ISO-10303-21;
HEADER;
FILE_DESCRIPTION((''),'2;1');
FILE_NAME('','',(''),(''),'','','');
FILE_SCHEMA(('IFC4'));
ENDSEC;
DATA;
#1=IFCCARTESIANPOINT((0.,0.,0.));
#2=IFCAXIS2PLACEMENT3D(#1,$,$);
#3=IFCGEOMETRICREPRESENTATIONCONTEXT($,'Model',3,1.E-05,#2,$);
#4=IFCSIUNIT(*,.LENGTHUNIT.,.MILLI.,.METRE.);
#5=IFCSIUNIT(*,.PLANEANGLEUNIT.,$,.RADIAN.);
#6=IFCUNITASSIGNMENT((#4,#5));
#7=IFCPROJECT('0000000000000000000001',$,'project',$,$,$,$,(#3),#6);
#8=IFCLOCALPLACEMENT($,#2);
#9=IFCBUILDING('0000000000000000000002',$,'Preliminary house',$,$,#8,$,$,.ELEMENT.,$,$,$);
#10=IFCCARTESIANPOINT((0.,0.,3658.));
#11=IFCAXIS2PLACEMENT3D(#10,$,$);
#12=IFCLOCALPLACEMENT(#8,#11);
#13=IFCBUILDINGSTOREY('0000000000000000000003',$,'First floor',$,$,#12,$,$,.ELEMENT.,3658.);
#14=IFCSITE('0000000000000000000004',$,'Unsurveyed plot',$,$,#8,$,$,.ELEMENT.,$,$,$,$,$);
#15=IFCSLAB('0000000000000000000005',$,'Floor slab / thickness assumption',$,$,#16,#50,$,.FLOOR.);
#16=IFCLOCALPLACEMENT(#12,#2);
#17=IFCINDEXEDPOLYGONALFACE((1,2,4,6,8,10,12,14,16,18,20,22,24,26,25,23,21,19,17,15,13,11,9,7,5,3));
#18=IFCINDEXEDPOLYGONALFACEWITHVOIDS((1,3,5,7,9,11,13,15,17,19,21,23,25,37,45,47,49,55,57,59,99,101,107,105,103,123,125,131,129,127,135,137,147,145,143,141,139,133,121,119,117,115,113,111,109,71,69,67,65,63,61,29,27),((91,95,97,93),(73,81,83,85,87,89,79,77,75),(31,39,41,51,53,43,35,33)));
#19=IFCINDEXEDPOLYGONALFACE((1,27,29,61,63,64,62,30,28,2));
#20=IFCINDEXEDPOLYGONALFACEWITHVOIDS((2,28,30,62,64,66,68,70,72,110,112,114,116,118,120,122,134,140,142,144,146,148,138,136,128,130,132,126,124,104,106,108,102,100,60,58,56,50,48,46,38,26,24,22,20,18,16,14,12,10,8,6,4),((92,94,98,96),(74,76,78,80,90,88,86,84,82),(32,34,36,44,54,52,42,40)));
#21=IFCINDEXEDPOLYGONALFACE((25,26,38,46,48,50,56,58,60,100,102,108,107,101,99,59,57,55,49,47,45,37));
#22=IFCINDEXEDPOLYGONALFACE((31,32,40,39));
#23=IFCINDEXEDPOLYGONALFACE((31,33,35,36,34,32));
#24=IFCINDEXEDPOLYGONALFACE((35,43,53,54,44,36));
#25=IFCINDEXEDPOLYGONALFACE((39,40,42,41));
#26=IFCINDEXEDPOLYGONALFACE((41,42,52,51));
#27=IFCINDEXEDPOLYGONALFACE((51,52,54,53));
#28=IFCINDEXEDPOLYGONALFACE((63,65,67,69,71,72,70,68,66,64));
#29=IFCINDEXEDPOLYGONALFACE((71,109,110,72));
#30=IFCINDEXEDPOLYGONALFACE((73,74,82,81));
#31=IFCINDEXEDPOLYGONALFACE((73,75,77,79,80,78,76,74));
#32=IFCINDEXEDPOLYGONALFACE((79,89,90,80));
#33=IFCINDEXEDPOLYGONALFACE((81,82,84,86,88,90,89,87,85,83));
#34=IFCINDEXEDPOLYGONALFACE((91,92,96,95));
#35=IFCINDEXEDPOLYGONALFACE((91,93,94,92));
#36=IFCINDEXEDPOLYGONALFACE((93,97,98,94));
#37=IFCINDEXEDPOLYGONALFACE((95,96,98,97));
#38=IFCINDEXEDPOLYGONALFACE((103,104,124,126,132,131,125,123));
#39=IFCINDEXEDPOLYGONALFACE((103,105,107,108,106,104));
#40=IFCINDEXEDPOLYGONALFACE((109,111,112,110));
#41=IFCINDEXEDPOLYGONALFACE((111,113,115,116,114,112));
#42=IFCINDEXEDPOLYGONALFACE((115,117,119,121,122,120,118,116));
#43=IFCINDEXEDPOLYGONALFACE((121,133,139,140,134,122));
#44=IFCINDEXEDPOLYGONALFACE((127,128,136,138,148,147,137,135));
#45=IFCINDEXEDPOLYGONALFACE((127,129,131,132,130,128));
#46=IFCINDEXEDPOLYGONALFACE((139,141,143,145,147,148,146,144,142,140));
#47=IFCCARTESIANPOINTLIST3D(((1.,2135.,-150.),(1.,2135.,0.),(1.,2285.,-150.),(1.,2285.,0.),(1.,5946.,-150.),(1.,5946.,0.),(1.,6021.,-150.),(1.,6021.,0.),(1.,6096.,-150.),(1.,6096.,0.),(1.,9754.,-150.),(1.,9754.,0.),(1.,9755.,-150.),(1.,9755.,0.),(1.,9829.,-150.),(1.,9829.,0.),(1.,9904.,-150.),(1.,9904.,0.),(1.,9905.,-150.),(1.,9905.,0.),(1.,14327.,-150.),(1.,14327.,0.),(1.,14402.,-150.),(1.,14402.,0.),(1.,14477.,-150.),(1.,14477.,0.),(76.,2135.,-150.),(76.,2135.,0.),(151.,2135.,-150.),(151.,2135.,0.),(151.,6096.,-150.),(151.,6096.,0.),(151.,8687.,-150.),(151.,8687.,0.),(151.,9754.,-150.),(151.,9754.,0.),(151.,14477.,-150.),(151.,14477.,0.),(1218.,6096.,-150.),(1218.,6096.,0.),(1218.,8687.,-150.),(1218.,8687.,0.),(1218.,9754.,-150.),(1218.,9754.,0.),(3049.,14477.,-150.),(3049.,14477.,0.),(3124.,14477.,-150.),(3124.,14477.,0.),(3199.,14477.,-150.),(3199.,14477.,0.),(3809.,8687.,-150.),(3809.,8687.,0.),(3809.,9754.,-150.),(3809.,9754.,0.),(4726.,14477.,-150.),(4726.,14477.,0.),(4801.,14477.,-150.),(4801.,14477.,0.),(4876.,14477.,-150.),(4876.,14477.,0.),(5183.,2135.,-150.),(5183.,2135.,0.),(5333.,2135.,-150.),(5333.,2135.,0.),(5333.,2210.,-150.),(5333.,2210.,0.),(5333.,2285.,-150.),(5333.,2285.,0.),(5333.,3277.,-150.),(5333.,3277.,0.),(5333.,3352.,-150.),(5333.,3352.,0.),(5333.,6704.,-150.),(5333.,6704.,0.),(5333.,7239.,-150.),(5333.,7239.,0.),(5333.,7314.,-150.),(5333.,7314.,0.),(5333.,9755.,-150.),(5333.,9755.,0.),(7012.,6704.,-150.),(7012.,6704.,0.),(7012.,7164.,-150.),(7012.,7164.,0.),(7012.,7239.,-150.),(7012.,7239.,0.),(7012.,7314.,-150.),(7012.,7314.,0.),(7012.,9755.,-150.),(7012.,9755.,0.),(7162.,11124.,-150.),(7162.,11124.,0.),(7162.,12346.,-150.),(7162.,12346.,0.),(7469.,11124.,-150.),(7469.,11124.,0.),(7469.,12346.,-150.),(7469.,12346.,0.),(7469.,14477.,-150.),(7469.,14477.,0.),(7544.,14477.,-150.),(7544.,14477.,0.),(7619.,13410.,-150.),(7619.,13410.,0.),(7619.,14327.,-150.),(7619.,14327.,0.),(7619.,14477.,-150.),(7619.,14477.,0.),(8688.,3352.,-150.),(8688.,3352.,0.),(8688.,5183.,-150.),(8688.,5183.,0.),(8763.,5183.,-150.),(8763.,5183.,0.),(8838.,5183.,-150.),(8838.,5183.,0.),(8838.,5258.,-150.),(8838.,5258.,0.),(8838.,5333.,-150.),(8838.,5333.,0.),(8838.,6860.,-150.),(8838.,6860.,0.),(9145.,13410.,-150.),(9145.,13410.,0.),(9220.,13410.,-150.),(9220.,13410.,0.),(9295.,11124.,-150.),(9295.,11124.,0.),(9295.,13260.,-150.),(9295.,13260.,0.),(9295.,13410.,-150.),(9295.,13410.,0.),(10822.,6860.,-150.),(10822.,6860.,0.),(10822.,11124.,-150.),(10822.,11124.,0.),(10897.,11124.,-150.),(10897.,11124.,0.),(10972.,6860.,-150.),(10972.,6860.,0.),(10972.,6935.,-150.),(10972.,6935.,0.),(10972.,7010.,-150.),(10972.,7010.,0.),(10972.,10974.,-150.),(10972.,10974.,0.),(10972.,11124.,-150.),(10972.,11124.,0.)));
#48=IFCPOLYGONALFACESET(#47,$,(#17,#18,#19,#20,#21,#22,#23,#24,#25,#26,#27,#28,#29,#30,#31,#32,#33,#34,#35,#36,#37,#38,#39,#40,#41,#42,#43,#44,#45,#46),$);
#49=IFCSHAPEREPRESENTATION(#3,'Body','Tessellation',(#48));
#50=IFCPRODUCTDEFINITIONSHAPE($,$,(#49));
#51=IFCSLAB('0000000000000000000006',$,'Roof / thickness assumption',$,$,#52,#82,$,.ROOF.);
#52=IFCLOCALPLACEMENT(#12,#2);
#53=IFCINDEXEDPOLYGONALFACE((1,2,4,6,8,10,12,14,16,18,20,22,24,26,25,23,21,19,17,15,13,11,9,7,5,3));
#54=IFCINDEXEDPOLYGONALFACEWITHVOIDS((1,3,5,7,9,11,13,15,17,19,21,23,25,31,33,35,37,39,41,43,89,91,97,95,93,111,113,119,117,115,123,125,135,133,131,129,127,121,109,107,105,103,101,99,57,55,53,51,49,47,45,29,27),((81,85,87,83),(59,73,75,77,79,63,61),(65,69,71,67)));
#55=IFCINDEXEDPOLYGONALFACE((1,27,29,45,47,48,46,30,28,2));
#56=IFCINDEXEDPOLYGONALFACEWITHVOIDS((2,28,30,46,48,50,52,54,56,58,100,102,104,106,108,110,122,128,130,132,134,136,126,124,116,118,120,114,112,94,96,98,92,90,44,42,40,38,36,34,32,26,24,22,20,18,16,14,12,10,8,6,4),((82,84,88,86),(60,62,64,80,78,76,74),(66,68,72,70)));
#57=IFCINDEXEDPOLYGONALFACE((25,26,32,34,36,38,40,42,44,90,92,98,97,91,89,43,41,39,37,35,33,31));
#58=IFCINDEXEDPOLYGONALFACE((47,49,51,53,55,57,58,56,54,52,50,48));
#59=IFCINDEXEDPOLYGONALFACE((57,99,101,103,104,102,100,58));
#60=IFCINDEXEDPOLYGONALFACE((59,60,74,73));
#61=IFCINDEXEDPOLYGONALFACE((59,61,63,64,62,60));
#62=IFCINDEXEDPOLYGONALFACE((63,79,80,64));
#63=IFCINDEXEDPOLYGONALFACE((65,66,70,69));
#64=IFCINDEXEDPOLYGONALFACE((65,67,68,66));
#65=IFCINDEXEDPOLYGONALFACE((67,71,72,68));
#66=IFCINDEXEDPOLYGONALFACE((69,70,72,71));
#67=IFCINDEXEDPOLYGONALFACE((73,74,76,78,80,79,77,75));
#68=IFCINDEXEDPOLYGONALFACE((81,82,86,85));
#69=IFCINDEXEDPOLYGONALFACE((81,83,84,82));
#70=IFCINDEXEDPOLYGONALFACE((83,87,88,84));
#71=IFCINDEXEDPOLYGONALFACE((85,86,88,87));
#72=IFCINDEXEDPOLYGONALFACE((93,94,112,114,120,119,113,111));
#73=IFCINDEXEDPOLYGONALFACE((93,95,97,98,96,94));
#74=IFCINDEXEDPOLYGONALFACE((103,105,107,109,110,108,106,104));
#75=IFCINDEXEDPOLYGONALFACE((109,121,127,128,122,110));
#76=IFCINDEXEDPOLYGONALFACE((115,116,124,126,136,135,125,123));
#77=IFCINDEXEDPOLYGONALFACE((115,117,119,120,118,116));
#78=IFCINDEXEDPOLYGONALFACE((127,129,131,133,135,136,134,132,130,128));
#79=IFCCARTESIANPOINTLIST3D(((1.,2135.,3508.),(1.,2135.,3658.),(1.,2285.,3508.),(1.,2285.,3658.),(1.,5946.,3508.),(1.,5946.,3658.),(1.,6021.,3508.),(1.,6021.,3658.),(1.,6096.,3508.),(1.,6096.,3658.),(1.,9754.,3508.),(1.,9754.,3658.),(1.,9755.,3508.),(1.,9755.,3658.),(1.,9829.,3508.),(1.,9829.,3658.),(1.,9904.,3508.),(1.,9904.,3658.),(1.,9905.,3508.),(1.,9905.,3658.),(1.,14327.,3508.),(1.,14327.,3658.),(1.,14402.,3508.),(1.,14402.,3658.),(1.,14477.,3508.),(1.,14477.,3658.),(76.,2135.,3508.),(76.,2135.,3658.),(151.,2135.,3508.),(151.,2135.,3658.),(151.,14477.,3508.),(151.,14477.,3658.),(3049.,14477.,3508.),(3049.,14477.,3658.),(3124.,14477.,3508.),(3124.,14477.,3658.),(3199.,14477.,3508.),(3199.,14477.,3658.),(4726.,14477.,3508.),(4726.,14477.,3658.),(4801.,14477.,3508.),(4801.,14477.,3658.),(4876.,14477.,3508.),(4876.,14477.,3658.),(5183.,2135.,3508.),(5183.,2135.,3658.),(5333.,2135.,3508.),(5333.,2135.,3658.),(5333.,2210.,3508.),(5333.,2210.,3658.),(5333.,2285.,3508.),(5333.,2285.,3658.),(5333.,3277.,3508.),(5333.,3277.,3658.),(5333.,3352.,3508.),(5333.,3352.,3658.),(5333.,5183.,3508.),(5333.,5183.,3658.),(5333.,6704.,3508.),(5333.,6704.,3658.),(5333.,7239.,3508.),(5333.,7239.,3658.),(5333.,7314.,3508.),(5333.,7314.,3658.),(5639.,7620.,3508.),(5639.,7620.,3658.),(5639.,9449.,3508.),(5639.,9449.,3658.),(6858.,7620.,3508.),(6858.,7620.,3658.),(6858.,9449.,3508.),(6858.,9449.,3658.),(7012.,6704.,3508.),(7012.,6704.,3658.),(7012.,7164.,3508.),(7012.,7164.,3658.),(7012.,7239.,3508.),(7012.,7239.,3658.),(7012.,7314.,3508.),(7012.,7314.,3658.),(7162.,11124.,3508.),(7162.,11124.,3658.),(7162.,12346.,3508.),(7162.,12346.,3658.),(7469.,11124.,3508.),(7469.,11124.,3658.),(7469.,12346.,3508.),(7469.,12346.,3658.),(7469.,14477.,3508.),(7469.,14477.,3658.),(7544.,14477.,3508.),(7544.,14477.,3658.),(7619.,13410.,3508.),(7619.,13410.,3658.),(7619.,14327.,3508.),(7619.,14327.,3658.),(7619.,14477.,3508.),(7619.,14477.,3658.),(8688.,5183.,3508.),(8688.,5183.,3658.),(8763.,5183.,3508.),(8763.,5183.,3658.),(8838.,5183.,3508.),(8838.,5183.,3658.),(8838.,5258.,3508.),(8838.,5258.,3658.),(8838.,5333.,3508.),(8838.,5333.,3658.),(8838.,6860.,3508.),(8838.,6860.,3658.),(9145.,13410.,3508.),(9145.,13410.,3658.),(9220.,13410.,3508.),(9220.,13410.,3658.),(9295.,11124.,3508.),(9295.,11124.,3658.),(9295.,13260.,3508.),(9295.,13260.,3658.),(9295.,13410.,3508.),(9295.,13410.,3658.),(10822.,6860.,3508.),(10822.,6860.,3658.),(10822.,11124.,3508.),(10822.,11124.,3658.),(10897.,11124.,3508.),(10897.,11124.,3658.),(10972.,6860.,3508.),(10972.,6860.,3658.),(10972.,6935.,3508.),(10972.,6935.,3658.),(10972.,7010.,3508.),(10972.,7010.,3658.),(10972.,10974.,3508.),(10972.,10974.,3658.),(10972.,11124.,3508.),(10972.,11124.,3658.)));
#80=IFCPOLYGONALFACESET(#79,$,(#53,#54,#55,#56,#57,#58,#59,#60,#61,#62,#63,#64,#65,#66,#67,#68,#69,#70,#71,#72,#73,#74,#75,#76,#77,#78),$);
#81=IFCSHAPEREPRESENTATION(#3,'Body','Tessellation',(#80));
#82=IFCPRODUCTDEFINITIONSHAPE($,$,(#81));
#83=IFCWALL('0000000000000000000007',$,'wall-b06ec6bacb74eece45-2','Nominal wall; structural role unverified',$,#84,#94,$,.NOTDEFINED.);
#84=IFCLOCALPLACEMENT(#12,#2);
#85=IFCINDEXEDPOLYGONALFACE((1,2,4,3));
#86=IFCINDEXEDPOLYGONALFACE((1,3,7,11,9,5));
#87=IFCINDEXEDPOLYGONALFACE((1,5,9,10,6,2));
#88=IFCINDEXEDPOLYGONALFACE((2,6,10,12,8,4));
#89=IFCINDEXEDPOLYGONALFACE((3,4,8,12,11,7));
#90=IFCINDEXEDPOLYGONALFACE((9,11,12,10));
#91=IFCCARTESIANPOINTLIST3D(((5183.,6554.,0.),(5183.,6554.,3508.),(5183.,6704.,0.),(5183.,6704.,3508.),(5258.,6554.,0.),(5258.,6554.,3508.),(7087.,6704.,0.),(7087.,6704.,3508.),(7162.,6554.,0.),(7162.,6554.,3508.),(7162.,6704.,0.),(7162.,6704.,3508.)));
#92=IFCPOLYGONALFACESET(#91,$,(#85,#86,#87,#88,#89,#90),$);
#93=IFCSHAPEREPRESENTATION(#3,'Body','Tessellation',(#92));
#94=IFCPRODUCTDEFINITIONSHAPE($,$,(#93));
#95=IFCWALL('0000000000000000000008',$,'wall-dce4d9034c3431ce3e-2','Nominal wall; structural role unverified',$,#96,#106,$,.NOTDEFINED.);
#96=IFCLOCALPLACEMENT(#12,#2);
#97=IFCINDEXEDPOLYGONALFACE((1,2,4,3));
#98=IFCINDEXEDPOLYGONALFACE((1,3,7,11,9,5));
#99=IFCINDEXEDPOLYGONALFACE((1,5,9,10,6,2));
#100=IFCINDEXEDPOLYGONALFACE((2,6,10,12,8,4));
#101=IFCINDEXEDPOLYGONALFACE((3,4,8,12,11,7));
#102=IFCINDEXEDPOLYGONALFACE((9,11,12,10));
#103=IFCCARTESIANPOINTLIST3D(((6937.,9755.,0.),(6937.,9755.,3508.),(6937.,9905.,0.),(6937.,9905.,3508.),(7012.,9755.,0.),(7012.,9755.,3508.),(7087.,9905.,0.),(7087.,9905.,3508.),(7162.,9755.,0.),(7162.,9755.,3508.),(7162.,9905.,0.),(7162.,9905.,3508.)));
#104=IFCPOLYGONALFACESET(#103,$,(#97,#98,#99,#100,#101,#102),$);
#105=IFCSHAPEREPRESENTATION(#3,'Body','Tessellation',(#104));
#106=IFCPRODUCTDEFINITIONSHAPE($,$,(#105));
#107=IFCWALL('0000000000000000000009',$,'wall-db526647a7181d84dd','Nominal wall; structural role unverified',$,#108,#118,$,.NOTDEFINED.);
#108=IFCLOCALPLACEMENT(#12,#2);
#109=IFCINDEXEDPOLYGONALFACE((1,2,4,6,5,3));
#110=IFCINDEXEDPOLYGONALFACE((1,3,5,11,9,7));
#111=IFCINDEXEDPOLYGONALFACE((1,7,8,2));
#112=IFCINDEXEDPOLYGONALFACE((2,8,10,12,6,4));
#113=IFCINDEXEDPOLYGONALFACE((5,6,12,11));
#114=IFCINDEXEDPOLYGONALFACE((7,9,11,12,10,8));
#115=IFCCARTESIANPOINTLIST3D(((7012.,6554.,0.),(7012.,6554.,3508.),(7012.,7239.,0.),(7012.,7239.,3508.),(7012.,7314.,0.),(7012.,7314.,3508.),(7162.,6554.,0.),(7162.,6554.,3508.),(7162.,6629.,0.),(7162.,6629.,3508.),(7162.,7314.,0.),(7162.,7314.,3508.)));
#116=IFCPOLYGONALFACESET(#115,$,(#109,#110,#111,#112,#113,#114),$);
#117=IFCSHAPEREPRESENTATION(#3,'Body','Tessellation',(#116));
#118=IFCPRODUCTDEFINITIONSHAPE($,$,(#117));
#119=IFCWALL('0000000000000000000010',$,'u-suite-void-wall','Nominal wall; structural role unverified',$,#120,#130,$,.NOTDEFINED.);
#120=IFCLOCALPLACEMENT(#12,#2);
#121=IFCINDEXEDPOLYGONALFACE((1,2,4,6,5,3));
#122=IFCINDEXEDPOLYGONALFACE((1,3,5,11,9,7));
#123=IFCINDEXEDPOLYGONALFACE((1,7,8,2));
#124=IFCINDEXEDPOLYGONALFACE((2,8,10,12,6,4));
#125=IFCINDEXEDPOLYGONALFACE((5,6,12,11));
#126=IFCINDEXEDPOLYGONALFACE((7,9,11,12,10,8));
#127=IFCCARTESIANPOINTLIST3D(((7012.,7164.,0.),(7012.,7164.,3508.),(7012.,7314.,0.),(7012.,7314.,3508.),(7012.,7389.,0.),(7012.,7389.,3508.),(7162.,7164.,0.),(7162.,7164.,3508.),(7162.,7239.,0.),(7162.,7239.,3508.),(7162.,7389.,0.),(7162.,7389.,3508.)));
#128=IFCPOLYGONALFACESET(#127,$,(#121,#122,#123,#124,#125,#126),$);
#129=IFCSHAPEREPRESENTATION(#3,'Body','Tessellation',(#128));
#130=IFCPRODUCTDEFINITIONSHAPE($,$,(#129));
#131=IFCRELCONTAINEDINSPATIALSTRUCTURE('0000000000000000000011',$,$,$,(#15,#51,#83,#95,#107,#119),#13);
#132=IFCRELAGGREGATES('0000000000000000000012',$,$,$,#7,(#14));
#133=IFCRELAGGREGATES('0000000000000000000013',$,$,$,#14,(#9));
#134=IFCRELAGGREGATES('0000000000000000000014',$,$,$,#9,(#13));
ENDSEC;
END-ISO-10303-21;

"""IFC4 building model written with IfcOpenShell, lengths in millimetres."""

from ifc_helpers import new_model, si_unit, frame, origin, place, context, project, spatial, polyline, outline, extrude, element, save


model = new_model("IFC4")

# Units and contexts
model_context = context("Model", 3, precision=1e-05, world=origin())
ifc_project = project(units=[si_unit("LENGTHUNIT", "METRE", prefix="MILLI"), si_unit("PLANEANGLEUNIT", "RADIAN")], contexts=[model_context])

# Site, building, storey
placement_1 = place(None, origin())
site = spatial("IfcSite", under=ifc_project, at=placement_1, Name="Unsurveyed plot", CompositionType="ELEMENT")
building = spatial("IfcBuilding", under=site, at=placement_1, Name="Preliminary house", CompositionType="ELEMENT")
placement_2 = place(placement_1, frame((0.0, 0.0, 3658.0)))
storey = spatial("IfcBuildingStorey", under=building, at=placement_2, Name="First floor", CompositionType="ELEMENT", Elevation=3658.0)

# Slabs
element("IfcSlab", 1, at=placement_2, inside=storey, Name="Floor slab / thickness assumption", PredefinedType="FLOOR", context=model_context, shape_type="SweptSolid", body=[
    extrude(outline(polyline([(1.0, 5946.0), (1.0, 6021.0), (1.0, 6096.0), (1.0, 9754.0), (1.0, 9755.0), (1.0, 9829.0), (1.0, 9904.0), (1.0, 9905.0), (1.0, 14327.0), (1.0, 14402.0), (1.0, 14477.0), (151.0, 14477.0), (3049.0, 14477.0), (3124.0, 14477.0), (3199.0, 14477.0), (4726.0, 14477.0), (4801.0, 14477.0), (4876.0, 14477.0), (7469.0, 14477.0), (7544.0, 14477.0), (7619.0, 14477.0), (7619.0, 14327.0), (7619.0, 13410.0), (9145.0, 13410.0), (9220.0, 13410.0), (9295.0, 13410.0), (9295.0, 13260.0), (9295.0, 11124.0), (10822.0, 11124.0), (10897.0, 11124.0), (10972.0, 11124.0), (10972.0, 10974.0), (10972.0, 7010.0), (10972.0, 6935.0), (10972.0, 6860.0), (10822.0, 6860.0), (8838.0, 6860.0), (8838.0, 5333.0), (8838.0, 5258.0), (8838.0, 5183.0), (8763.0, 5183.0), (8688.0, 5183.0), (8688.0, 3352.0), (5333.0, 3352.0), (5333.0, 3277.0), (5333.0, 2285.0), (5333.0, 2210.0), (5333.0, 2135.0), (5183.0, 2135.0), (151.0, 2135.0), (76.0, 2135.0), (1.0, 2135.0), (1.0, 2285.0), (1.0, 5946.0)]), holes=[polyline([(7012.0, 7239.0), (7012.0, 7314.0), (7012.0, 9755.0), (5333.0, 9755.0), (5333.0, 7314.0), (5333.0, 7239.0), (5333.0, 6704.0), (7012.0, 6704.0), (7012.0, 7164.0), (7012.0, 7239.0)]), polyline([(7469.0, 11124.0), (7469.0, 12346.0), (7162.0, 12346.0), (7162.0, 11124.0), (7469.0, 11124.0)]), polyline([(1218.0, 8687.0), (3809.0, 8687.0), (3809.0, 9754.0), (1218.0, 9754.0), (151.0, 9754.0), (151.0, 8687.0), (151.0, 6096.0), (1218.0, 6096.0), (1218.0, 8687.0)])]), frame((0.0, 0.0, -150.0)), (0.0, 0.0, 1.0), 150.0),
])
element("IfcSlab", 2, at=placement_2, inside=storey, Name="Roof / thickness assumption", PredefinedType="ROOF", context=model_context, shape_type="SweptSolid", body=[
    extrude(outline(polyline([(1.0, 5946.0), (1.0, 6021.0), (1.0, 6096.0), (1.0, 9754.0), (1.0, 9755.0), (1.0, 9829.0), (1.0, 9904.0), (1.0, 9905.0), (1.0, 14327.0), (1.0, 14402.0), (1.0, 14477.0), (151.0, 14477.0), (3049.0, 14477.0), (3124.0, 14477.0), (3199.0, 14477.0), (4726.0, 14477.0), (4801.0, 14477.0), (4876.0, 14477.0), (7469.0, 14477.0), (7544.0, 14477.0), (7619.0, 14477.0), (7619.0, 14327.0), (7619.0, 13410.0), (9145.0, 13410.0), (9220.0, 13410.0), (9295.0, 13410.0), (9295.0, 13260.0), (9295.0, 11124.0), (10822.0, 11124.0), (10897.0, 11124.0), (10972.0, 11124.0), (10972.0, 10974.0), (10972.0, 7010.0), (10972.0, 6935.0), (10972.0, 6860.0), (10822.0, 6860.0), (8838.0, 6860.0), (8838.0, 5333.0), (8838.0, 5258.0), (8838.0, 5183.0), (8763.0, 5183.0), (8688.0, 5183.0), (5333.0, 5183.0), (5333.0, 3352.0), (5333.0, 3277.0), (5333.0, 2285.0), (5333.0, 2210.0), (5333.0, 2135.0), (5183.0, 2135.0), (151.0, 2135.0), (76.0, 2135.0), (1.0, 2135.0), (1.0, 2285.0), (1.0, 5946.0)]), holes=[polyline([(7012.0, 7239.0), (7012.0, 7314.0), (5333.0, 7314.0), (5333.0, 7239.0), (5333.0, 6704.0), (7012.0, 6704.0), (7012.0, 7164.0), (7012.0, 7239.0)]), polyline([(7469.0, 11124.0), (7469.0, 12346.0), (7162.0, 12346.0), (7162.0, 11124.0), (7469.0, 11124.0)]), polyline([(6858.0, 7620.0), (6858.0, 9449.0), (5639.0, 9449.0), (5639.0, 7620.0), (6858.0, 7620.0)])]), frame((0.0, 0.0, 3508.0)), (0.0, 0.0, 1.0), 150.0),
])

# Walls
element("IfcWall", 3, at=placement_2, inside=storey, Name="wall-b06ec6bacb74eece45-2", Description="Nominal wall; structural role unverified", PredefinedType="NOTDEFINED", context=model_context, shape_type="SweptSolid", body=[
    extrude(outline(polyline([(7087.0, 6704.0), (7162.0, 6704.0), (7162.0, 6554.0), (5258.0, 6554.0), (5183.0, 6554.0), (5183.0, 6704.0), (7087.0, 6704.0)])), origin(), (0.0, 0.0, 1.0), 3508.0),
])
element("IfcWall", 4, at=placement_2, inside=storey, Name="wall-dce4d9034c3431ce3e-2", Description="Nominal wall; structural role unverified", PredefinedType="NOTDEFINED", context=model_context, shape_type="SweptSolid", body=[
    extrude(outline(polyline([(7087.0, 9905.0), (7162.0, 9905.0), (7162.0, 9755.0), (7012.0, 9755.0), (6937.0, 9755.0), (6937.0, 9905.0), (7087.0, 9905.0)])), origin(), (0.0, 0.0, 1.0), 3508.0),
])
element("IfcWall", 5, at=placement_2, inside=storey, Name="wall-db526647a7181d84dd", Description="Nominal wall; structural role unverified", PredefinedType="NOTDEFINED", context=model_context, shape_type="SweptSolid", body=[
    extrude(outline(polyline([(7012.0, 7239.0), (7012.0, 7314.0), (7162.0, 7314.0), (7162.0, 6629.0), (7162.0, 6554.0), (7012.0, 6554.0), (7012.0, 7239.0)])), origin(), (0.0, 0.0, 1.0), 3508.0),
])
element("IfcWall", 6, at=placement_2, inside=storey, Name="u-suite-void-wall", Description="Nominal wall; structural role unverified", PredefinedType="NOTDEFINED", context=model_context, shape_type="SweptSolid", body=[
    extrude(outline(polyline([(7012.0, 7314.0), (7012.0, 7389.0), (7162.0, 7389.0), (7162.0, 7239.0), (7162.0, 7164.0), (7012.0, 7164.0), (7012.0, 7314.0)])), origin(), (0.0, 0.0, 1.0), 3508.0),
])

save(model, "model.ifc")
